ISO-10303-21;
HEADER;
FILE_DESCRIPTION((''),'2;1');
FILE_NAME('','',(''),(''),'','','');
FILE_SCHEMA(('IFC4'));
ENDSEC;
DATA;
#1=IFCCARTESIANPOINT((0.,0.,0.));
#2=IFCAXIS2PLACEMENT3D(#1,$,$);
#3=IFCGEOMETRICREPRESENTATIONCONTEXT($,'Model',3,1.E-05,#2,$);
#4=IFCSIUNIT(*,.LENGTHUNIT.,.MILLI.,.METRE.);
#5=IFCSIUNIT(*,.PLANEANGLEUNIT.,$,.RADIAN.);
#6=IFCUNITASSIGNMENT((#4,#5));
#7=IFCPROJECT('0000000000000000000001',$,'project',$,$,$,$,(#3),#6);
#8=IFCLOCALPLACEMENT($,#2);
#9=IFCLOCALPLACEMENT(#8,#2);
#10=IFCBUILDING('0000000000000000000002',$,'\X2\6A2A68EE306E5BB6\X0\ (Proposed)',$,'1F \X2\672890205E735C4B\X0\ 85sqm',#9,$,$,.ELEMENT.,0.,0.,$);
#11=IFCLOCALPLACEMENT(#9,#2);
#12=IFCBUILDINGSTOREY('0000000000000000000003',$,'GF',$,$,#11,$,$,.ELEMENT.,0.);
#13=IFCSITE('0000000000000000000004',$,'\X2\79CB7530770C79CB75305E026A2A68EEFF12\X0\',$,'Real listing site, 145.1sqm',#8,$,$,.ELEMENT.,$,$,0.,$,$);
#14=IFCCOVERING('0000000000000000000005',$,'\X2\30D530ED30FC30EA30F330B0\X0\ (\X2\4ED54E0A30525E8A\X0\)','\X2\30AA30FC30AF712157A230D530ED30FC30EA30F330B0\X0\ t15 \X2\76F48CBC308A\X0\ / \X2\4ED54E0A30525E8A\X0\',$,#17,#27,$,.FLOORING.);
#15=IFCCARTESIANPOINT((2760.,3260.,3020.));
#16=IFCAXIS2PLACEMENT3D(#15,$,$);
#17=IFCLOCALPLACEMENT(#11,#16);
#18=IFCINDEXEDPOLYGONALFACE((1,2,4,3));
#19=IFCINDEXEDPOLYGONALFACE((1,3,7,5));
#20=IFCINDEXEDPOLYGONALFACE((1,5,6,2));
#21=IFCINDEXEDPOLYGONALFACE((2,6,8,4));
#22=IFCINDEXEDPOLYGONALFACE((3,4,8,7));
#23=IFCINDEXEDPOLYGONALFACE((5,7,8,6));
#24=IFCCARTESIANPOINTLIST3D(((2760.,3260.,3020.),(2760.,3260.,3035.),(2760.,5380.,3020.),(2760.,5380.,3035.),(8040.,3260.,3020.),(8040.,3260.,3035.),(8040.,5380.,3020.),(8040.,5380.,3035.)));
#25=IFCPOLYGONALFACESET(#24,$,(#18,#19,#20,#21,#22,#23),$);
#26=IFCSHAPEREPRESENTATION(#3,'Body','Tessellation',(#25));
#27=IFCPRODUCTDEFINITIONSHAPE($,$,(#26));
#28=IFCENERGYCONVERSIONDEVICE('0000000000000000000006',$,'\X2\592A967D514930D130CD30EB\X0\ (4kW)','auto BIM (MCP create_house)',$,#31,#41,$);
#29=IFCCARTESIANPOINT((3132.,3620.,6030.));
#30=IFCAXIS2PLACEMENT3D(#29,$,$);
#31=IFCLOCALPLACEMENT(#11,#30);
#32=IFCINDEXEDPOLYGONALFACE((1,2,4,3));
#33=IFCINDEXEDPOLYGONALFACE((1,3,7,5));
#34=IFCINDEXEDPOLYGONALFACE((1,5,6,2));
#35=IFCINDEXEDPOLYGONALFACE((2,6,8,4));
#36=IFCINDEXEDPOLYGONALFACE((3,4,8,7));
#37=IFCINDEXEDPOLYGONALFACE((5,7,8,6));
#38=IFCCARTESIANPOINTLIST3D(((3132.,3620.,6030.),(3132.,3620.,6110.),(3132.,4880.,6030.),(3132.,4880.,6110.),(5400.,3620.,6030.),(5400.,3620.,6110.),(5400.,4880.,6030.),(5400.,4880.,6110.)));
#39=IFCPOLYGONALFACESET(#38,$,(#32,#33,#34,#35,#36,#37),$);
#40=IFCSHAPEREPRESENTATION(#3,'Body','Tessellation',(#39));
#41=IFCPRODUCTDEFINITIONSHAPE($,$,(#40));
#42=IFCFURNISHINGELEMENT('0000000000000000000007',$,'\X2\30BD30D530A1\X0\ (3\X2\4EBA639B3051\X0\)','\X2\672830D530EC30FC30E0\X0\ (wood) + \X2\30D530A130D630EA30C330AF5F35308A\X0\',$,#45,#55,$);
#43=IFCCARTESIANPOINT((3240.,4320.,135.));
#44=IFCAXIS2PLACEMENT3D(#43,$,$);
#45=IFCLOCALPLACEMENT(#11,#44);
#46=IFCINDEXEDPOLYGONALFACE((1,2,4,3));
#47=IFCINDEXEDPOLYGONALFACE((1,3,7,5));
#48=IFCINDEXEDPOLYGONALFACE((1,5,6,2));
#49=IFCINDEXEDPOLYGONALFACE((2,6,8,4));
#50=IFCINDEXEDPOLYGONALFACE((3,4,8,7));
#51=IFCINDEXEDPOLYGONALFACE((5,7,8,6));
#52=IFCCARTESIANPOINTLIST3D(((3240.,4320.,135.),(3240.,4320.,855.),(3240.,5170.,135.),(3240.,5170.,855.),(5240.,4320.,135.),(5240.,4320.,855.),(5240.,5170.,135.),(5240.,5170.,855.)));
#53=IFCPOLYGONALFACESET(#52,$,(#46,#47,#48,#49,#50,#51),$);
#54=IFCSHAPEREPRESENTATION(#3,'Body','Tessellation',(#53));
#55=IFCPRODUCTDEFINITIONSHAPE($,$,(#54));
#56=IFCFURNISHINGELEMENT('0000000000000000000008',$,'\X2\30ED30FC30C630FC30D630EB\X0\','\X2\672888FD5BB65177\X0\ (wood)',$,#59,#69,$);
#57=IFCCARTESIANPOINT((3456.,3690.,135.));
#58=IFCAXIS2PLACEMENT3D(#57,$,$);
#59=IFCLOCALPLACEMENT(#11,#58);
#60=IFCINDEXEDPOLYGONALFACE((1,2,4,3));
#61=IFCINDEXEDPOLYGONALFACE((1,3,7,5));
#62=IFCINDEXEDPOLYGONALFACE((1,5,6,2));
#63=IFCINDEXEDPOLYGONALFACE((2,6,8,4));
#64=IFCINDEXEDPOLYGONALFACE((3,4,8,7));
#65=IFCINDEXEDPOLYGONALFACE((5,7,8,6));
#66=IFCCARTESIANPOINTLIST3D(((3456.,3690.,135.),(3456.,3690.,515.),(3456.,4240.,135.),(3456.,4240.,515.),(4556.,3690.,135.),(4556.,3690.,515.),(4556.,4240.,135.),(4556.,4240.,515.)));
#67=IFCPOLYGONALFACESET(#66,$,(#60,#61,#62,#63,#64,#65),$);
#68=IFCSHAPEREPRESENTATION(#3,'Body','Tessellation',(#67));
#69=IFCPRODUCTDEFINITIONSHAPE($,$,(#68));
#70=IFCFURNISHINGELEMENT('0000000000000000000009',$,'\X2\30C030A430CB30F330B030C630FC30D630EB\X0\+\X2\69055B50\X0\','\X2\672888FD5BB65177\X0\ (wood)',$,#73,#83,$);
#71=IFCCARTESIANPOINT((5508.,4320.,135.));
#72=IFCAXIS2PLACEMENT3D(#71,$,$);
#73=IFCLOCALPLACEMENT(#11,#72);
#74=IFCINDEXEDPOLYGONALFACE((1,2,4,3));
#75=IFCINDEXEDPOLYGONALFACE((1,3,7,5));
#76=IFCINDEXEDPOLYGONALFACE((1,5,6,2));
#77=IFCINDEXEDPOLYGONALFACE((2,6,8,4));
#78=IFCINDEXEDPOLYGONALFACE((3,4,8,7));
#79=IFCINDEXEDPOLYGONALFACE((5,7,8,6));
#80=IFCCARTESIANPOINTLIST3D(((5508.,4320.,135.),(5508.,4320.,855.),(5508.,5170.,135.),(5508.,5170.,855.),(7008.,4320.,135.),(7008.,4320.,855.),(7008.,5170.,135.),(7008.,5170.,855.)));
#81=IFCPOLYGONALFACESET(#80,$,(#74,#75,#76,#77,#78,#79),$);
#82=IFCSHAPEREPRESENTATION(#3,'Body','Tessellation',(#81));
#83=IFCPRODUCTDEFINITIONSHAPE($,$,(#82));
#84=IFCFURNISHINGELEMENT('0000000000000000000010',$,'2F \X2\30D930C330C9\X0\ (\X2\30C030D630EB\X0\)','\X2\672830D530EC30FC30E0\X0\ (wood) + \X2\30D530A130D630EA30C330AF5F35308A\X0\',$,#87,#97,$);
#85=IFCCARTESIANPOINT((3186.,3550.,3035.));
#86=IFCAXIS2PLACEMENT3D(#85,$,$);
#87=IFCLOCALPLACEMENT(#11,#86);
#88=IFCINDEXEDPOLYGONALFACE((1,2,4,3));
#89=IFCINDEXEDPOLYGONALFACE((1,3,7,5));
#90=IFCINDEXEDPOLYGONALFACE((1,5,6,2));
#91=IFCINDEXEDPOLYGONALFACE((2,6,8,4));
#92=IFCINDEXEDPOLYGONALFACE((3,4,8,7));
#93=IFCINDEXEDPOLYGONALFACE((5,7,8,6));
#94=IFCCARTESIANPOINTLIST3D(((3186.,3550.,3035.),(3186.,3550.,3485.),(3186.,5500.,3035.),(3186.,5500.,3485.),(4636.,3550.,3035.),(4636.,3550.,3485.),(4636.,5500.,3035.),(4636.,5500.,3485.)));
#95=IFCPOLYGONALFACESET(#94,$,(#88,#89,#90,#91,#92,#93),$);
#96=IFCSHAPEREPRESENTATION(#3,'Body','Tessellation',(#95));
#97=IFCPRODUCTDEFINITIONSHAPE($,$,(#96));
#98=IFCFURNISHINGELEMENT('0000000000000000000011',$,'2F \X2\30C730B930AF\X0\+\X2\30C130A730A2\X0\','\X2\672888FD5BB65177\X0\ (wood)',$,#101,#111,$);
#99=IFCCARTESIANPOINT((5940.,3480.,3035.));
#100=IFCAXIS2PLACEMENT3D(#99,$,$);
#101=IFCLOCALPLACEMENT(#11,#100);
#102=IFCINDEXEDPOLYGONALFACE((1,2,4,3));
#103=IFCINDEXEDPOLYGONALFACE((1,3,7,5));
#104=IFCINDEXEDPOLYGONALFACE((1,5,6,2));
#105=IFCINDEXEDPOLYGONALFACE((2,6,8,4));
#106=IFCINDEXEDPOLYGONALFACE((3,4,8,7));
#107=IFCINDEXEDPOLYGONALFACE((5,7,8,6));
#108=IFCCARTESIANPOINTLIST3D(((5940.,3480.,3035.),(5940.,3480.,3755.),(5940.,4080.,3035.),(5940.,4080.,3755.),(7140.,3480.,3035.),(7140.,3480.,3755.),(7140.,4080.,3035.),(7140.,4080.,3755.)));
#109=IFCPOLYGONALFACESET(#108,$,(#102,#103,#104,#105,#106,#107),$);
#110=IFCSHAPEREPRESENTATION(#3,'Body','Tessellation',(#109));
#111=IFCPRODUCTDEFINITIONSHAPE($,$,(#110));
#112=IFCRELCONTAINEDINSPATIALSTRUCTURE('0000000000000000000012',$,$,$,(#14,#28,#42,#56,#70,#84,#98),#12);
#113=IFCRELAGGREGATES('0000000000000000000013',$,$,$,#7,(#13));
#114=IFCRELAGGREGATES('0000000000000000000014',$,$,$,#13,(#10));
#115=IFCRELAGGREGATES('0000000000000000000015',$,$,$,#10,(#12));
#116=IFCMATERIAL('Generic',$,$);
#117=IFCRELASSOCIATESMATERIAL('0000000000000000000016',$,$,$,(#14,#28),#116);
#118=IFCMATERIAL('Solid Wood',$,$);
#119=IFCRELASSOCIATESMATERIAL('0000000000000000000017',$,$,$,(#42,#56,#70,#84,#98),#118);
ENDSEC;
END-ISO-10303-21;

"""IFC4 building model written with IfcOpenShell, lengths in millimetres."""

from ifc_helpers import new_model, si_unit, frame, frame_2d, origin, place, context, project, spatial, rectangle, extrude, material, element, save


model = new_model("IFC4")

# Units and contexts
model_context = context("Model", 3, precision=1e-05, world=origin())
ifc_project = project(units=[si_unit("LENGTHUNIT", "METRE", prefix="MILLI"), si_unit("PLANEANGLEUNIT", "RADIAN")], contexts=[model_context])

# Site, building, storey
site_placement = place(None, origin())
site = spatial("IfcSite", under=ifc_project, at=site_placement, Name="秋田県秋田市横森２", ObjectType="Real listing site, 145.1sqm", CompositionType="ELEMENT", RefElevation=0.0)
building_placement = place(site_placement, origin())
building = spatial("IfcBuilding", under=site, at=building_placement, Name="横森の家 (Proposed)", ObjectType="1F 木造平屋 85sqm", CompositionType="ELEMENT", ElevationOfRefHeight=0.0, ElevationOfTerrain=0.0)
storey_placement = place(building_placement, origin())
storey = spatial("IfcBuildingStorey", under=building, at=storey_placement, Name="GF", CompositionType="ELEMENT", Elevation=0.0)

# Shared definitions
ifc_material_1 = material(Name="Solid Wood")

# Covering
ifc_material_2 = material(Name="Generic")
covering_placement = place(storey_placement, frame((2760.0, 3260.0, 3020.0)))
element("IfcCovering", 1, at=covering_placement, inside=storey, material=ifc_material_2, Name="フローリング (仕上げ床)", Description="オーク無垢フローリング t15 直貼り / 仕上げ床", PredefinedType="FLOORING", context=model_context, shape_type="SweptSolid", body=[
    extrude(rectangle(XDim=5280.0, YDim=2120.0, at=frame_2d((2640.0, 1060.0))), frame((2760.0, 3260.0, 3020.0)), (0.0, 0.0, 1.0), 15.0),
])

# Energy conversion device
energy_conversion_device_placement = place(storey_placement, frame((3132.0, 3620.0, 6030.0)))
element("IfcEnergyConversionDevice", 2, at=energy_conversion_device_placement, inside=storey, material=ifc_material_2, Name="太陽光パネル (4kW)", Description="auto BIM (MCP create_house)", context=model_context, shape_type="SweptSolid", body=[
    extrude(rectangle(XDim=2268.0, YDim=1260.0, at=frame_2d((1134.0, 630.0))), frame((3132.0, 3620.0, 6030.0)), (0.0, 0.0, 1.0), 80.0),
])

# Furnishing elements
furnishing_1_placement = place(storey_placement, frame((3240.0, 4320.0, 135.0)))
element("IfcFurnishingElement", 3, at=furnishing_1_placement, inside=storey, material=ifc_material_1, Name="ソファ (3人掛け)", Description="木フレーム (wood) + ファブリック張り", context=model_context, shape_type="SweptSolid", body=[
    extrude(rectangle(XDim=2000.0, YDim=850.0, at=frame_2d((1000.0, 425.0))), frame((3240.0, 4320.0, 135.0)), (0.0, 0.0, 1.0), 720.0),
])
furnishing_2_placement = place(storey_placement, frame((3456.0, 3690.0, 135.0)))
element("IfcFurnishingElement", 4, at=furnishing_2_placement, inside=storey, material=ifc_material_1, Name="ローテーブル", Description="木製家具 (wood)", context=model_context, shape_type="SweptSolid", body=[
    extrude(rectangle(XDim=1100.0, YDim=550.0, at=frame_2d((550.0, 275.0))), frame((3456.0, 3690.0, 135.0)), (0.0, 0.0, 1.0), 380.0),
])
furnishing_3_placement = place(storey_placement, frame((5508.0, 4320.0, 135.0)))
element("IfcFurnishingElement", 5, at=furnishing_3_placement, inside=storey, material=ifc_material_1, Name="ダイニングテーブル+椅子", Description="木製家具 (wood)", context=model_context, shape_type="SweptSolid", body=[
    extrude(rectangle(XDim=1500.0, YDim=850.0, at=frame_2d((750.0, 425.0))), frame((5508.0, 4320.0, 135.0)), (0.0, 0.0, 1.0), 720.0),
])
furnishing_4_placement = place(storey_placement, frame((3186.0, 3550.0, 3035.0)))
element("IfcFurnishingElement", 6, at=furnishing_4_placement, inside=storey, material=ifc_material_1, Name="2F ベッド (ダブル)", Description="木フレーム (wood) + ファブリック張り", context=model_context, shape_type="SweptSolid", body=[
    extrude(rectangle(XDim=1450.0, YDim=1950.0, at=frame_2d((725.0, 975.0))), frame((3186.0, 3550.0, 3035.0)), (0.0, 0.0, 1.0), 450.0),
])
furnishing_5_placement = place(storey_placement, frame((5940.0, 3480.0, 3035.0)))
element("IfcFurnishingElement", 7, at=furnishing_5_placement, inside=storey, material=ifc_material_1, Name="2F デスク+チェア", Description="木製家具 (wood)", context=model_context, shape_type="SweptSolid", body=[
    extrude(rectangle(XDim=1200.0, YDim=600.0, at=frame_2d((600.0, 300.0))), frame((5940.0, 3480.0, 3035.0)), (0.0, 0.0, 1.0), 720.0),
])

save(model, "model.ifc")
